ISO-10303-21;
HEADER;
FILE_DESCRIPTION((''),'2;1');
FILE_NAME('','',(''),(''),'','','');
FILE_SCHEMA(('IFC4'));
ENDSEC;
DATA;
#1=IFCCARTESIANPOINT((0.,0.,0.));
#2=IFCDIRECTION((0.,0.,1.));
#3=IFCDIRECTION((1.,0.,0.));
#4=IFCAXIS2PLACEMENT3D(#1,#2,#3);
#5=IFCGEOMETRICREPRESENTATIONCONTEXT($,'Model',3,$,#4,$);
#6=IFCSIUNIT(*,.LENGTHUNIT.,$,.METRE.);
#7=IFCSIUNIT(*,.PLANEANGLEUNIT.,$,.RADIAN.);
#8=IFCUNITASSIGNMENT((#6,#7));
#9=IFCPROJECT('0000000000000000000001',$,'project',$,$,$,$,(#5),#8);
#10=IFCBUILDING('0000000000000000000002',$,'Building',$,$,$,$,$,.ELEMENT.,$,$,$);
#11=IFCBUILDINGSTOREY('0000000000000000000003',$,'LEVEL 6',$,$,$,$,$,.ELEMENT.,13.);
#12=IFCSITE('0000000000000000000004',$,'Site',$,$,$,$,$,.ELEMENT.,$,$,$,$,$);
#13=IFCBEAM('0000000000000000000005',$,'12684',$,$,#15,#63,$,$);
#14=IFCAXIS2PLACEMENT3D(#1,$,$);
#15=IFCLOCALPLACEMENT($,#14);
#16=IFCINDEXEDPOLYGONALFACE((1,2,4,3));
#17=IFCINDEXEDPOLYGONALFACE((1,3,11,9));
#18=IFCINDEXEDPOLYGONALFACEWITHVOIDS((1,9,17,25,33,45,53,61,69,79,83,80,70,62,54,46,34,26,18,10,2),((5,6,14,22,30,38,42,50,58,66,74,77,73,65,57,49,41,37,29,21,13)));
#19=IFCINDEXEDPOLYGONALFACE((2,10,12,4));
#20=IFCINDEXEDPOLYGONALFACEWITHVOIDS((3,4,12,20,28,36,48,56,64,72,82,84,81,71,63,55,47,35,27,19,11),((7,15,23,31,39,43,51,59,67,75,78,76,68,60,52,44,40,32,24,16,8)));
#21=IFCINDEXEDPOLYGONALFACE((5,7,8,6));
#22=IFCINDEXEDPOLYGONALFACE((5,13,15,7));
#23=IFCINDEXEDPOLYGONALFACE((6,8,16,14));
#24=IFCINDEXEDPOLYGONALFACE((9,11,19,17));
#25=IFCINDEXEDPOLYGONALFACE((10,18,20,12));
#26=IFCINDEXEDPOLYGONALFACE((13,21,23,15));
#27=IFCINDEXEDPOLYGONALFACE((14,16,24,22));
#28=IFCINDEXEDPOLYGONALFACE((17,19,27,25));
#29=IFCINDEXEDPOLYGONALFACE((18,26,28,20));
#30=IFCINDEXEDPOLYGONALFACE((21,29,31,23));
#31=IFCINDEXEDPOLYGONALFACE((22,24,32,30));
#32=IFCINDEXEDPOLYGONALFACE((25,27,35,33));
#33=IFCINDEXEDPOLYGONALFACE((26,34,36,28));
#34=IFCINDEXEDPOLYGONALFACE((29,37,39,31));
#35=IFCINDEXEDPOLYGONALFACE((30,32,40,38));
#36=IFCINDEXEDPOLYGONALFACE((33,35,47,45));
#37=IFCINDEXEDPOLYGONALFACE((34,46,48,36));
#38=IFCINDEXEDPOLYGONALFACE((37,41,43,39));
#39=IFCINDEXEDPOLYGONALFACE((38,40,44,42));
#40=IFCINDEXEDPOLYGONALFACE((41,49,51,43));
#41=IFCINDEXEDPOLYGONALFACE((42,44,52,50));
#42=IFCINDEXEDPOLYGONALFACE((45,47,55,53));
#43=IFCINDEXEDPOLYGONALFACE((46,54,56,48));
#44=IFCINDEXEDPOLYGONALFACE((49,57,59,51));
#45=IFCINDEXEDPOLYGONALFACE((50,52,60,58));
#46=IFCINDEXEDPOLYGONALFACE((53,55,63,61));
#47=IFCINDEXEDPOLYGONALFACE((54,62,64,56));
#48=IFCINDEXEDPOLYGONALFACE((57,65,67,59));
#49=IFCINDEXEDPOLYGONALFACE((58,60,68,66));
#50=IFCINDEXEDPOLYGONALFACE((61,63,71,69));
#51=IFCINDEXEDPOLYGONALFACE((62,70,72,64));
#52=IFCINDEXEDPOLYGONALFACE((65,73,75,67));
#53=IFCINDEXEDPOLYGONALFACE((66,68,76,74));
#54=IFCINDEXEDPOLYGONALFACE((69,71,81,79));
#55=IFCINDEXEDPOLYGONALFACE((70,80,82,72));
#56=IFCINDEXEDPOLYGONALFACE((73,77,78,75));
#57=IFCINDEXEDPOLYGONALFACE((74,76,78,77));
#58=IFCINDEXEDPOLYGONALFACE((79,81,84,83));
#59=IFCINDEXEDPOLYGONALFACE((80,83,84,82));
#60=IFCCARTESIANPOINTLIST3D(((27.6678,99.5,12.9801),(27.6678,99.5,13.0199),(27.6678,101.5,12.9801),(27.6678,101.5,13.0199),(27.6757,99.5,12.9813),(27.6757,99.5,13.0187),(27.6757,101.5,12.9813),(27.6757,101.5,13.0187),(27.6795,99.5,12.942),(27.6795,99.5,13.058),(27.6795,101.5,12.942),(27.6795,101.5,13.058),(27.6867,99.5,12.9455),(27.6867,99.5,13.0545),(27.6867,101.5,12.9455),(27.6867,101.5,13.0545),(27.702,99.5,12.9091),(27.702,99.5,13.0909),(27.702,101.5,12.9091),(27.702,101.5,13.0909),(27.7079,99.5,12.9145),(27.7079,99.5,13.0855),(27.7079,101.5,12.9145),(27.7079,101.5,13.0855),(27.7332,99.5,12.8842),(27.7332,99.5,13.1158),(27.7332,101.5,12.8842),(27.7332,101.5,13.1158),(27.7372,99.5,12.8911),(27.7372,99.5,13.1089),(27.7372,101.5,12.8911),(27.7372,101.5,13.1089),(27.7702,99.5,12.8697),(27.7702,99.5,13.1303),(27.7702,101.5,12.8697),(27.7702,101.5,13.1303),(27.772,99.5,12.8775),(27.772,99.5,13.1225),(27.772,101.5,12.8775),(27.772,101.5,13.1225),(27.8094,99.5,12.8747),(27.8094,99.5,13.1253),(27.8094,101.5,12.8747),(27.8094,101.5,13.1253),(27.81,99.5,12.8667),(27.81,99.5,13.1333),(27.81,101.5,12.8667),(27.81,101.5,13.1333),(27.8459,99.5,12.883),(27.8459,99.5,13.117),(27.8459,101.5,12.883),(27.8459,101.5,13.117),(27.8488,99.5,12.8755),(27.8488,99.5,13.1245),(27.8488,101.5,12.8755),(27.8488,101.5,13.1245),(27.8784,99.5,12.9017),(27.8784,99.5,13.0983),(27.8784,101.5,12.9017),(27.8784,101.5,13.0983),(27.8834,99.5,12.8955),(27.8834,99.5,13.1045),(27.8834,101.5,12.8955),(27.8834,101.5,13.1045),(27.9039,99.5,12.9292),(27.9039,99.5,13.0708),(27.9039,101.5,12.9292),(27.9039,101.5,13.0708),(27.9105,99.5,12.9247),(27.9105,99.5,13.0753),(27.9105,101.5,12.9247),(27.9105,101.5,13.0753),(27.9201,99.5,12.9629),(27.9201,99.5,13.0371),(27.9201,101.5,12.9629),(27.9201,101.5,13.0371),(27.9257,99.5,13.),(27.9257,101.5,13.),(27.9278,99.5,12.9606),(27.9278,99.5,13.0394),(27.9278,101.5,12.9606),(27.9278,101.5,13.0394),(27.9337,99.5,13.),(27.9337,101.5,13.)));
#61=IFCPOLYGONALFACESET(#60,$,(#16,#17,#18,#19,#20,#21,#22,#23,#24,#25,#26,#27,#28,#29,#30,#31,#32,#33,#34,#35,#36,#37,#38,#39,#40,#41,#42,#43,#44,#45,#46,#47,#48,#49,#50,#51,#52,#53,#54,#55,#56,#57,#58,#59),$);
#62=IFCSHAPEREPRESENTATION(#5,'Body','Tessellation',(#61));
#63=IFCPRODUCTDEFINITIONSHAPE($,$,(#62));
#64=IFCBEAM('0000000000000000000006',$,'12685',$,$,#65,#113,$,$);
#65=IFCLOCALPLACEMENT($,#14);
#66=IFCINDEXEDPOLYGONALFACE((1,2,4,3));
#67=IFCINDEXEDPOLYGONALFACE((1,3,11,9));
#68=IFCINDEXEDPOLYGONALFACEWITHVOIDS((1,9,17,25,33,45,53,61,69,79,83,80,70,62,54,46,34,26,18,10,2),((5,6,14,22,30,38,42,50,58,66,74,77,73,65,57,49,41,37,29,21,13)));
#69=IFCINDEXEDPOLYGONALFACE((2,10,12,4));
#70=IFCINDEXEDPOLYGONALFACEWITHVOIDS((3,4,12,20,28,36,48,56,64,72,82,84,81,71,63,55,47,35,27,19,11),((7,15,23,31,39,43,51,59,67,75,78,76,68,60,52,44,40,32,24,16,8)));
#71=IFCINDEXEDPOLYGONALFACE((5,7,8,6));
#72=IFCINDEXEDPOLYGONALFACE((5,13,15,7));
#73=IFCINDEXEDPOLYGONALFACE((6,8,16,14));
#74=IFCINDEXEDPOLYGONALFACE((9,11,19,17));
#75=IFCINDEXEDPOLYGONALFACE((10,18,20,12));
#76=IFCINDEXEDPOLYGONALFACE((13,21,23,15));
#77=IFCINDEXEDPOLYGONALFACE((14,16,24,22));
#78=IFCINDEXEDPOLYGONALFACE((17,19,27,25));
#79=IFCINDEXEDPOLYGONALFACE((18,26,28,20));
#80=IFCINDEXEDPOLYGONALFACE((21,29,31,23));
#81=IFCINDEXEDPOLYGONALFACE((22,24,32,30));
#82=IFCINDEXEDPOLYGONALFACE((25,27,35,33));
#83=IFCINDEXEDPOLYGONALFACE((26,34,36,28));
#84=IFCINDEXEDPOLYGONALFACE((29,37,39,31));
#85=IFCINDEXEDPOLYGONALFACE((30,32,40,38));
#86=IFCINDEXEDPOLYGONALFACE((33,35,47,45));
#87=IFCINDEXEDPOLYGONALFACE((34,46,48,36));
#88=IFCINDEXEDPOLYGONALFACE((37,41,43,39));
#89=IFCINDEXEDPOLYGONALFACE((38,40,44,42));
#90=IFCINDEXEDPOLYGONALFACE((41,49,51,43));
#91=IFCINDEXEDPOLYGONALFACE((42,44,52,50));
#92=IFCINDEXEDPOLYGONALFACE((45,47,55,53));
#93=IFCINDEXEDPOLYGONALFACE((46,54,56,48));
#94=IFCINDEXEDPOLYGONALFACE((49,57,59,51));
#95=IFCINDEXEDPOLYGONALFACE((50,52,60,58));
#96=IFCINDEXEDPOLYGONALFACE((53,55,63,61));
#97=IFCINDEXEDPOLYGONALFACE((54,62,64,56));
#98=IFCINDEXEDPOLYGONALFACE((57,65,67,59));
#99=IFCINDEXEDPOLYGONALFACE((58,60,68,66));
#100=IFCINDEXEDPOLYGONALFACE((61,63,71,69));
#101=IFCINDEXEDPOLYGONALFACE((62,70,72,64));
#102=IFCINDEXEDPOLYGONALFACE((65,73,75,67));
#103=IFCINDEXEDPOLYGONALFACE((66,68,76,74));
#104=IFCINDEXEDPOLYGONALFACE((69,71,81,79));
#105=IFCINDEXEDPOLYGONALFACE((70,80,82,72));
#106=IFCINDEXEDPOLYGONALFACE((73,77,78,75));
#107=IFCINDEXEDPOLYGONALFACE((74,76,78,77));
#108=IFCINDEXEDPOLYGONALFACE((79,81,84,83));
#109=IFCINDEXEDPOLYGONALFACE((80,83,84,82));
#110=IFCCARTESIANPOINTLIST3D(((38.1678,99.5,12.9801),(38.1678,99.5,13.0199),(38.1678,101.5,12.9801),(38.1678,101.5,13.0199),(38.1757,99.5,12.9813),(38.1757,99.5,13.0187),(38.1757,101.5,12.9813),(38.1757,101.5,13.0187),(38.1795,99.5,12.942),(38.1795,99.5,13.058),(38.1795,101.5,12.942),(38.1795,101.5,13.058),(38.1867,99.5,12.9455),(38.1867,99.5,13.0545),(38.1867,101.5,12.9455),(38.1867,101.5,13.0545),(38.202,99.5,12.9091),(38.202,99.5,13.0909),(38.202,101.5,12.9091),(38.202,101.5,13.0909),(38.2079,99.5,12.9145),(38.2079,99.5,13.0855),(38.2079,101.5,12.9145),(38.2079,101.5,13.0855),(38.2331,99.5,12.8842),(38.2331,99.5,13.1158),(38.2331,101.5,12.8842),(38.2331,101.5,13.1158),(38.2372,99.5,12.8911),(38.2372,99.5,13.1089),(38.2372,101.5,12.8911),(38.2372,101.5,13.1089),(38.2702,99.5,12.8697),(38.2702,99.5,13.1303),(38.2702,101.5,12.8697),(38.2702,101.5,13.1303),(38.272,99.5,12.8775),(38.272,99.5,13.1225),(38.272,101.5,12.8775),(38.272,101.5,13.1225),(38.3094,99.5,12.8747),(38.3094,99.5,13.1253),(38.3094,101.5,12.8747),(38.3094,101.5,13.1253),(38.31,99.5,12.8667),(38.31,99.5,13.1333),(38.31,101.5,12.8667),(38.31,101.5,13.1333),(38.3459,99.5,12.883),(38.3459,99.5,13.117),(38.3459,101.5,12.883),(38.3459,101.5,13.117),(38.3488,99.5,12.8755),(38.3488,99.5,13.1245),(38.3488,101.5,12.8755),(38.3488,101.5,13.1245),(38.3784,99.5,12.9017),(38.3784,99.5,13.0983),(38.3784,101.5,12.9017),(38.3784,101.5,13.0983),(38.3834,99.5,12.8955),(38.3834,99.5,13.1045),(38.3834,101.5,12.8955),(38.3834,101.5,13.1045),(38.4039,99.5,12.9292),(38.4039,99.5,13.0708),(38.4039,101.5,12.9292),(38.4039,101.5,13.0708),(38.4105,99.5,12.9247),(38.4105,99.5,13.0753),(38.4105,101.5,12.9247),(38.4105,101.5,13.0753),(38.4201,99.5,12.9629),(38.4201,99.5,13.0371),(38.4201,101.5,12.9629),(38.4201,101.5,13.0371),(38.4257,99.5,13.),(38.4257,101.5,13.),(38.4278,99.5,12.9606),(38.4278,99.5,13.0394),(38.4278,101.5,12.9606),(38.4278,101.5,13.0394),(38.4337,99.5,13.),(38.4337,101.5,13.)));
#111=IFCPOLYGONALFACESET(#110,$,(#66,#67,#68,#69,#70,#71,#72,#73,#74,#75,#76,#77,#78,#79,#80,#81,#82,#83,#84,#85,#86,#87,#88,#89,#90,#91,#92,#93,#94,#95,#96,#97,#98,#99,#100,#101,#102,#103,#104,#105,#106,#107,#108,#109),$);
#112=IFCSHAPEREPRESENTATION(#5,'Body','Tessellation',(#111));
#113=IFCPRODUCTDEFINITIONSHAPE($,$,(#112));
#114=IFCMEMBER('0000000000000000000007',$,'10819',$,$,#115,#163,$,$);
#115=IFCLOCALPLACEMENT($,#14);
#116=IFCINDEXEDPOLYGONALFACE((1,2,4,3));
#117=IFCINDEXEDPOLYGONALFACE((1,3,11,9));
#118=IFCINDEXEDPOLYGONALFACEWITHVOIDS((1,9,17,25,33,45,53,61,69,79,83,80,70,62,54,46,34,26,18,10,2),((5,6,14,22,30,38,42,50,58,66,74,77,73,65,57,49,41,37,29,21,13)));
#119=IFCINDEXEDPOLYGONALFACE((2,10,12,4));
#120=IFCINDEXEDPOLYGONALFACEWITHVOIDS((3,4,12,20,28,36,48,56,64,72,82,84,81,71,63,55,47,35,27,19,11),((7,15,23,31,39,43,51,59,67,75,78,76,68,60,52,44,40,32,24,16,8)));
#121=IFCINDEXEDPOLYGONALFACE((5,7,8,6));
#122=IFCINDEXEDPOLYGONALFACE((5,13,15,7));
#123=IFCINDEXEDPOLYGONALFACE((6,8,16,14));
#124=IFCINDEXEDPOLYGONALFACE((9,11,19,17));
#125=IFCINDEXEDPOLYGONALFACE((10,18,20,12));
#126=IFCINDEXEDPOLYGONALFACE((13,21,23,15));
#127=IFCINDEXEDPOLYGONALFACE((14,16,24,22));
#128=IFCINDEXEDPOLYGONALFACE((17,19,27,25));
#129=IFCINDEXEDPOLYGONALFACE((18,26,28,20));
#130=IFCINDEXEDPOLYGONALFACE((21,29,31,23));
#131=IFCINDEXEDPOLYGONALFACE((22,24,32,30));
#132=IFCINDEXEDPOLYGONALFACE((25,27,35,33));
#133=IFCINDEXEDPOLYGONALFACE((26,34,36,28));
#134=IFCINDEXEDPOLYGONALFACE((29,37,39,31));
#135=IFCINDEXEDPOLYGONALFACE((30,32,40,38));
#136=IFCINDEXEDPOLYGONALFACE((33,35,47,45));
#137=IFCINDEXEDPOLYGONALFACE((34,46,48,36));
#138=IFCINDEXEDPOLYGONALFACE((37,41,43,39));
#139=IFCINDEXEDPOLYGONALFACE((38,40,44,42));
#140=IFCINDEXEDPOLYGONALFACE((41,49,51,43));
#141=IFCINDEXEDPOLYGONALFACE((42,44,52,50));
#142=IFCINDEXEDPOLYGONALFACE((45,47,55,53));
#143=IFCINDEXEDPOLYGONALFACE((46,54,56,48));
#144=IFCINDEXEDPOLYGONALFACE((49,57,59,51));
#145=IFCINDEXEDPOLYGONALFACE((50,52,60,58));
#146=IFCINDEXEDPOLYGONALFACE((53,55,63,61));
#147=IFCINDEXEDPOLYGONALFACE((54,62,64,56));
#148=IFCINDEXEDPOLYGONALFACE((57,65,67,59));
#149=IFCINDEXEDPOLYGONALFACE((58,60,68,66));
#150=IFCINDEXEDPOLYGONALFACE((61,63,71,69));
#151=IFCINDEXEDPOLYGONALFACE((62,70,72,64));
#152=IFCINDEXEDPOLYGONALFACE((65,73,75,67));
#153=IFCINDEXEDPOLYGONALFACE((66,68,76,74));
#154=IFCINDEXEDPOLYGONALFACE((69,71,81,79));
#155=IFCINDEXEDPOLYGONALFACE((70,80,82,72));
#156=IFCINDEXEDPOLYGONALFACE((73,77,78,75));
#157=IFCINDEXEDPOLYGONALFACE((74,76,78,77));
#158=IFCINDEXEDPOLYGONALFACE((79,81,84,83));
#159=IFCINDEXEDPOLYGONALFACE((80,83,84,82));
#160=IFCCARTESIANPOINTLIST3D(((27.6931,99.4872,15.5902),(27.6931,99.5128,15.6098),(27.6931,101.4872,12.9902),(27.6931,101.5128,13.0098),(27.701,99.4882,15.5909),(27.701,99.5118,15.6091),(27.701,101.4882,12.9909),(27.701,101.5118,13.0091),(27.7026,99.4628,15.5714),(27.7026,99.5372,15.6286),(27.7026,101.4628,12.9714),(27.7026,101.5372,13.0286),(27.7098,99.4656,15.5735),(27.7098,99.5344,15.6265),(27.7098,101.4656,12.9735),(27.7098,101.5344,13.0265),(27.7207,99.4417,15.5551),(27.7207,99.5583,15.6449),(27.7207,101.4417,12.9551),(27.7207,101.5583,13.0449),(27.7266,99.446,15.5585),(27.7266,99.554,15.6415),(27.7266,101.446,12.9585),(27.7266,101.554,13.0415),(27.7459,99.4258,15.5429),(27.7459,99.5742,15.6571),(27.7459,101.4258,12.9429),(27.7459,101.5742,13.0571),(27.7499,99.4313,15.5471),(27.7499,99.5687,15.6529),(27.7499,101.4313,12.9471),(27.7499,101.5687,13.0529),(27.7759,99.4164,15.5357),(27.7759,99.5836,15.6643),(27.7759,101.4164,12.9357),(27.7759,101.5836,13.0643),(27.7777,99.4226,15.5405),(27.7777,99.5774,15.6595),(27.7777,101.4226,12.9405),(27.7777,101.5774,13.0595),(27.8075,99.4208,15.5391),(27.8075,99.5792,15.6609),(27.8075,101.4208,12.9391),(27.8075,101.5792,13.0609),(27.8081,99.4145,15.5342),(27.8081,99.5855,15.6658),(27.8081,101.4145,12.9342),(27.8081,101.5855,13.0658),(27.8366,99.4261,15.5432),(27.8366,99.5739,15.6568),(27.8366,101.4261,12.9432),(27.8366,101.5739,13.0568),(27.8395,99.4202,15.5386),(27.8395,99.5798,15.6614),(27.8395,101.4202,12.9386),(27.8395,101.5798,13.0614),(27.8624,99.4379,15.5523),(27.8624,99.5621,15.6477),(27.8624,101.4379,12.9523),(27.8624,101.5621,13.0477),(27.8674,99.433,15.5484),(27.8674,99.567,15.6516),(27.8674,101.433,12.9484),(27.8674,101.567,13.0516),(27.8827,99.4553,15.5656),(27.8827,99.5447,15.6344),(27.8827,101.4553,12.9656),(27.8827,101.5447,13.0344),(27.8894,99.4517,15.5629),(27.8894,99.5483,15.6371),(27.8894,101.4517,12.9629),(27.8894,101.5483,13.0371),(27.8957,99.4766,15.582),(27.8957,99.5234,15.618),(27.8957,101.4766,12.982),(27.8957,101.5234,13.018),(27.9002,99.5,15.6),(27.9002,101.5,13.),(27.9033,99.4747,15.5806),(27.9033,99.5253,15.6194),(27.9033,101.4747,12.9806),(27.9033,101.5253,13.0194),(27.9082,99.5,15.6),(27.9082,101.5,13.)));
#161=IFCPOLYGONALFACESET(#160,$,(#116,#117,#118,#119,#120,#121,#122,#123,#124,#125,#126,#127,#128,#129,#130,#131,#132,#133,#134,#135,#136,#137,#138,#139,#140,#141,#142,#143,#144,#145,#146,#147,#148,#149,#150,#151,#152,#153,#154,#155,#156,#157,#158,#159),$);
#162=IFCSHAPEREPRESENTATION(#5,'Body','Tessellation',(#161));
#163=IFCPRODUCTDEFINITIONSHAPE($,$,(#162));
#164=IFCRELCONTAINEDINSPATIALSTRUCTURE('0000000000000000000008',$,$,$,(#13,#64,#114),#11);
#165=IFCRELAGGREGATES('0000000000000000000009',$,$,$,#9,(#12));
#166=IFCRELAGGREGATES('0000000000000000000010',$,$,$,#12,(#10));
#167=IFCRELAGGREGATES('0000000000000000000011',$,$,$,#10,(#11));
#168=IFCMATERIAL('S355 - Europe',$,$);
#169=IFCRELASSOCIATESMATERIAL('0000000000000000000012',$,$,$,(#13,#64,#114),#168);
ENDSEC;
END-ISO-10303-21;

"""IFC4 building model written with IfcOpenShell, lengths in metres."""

from ifc_helpers import new_model, si_unit, frame, origin_with_axes, origin_2d_with_axis, place, context, project, spatial, hollow_circle, extrude, material, material_profile, profile_set, profile_usage, element, save


model = new_model("IFC4")

# Units and contexts
model_context = context("Model", 3, world=origin_with_axes())
ifc_project = project(units=[si_unit("LENGTHUNIT", "METRE"), si_unit("PLANEANGLEUNIT", "RADIAN")], contexts=[model_context])

# Site, building, storey
site = spatial("IfcSite", under=ifc_project, Name="Site", CompositionType="ELEMENT")
building = spatial("IfcBuilding", under=site, Name="Building", CompositionType="ELEMENT")
storey = spatial("IfcBuildingStorey", under=building, Name="LEVEL 6", CompositionType="ELEMENT", Elevation=13.0)

# Shared definitions
ifc_material = material(Name="S355 - Europe")

# Beams
ifc_material_profile_1 = material_profile(ifc_material, hollow_circle(Radius=0.1337, WallThickness=0.008, at=origin_2d_with_axis()))
ifc_profile_set_1 = profile_set([ifc_material_profile_1])
ifc_profile_usage_1 = profile_usage(ifc_profile_set_1, cardinal=10)
beam_1_placement = place(None, frame((27.8, 101.5, 13.0), z_axis=(0.0, -1.0, 0.0), x_axis=(1.0, 0.0, 0.0)))
element("IfcBeam", 1, at=beam_1_placement, inside=storey, material=ifc_profile_usage_1, Name="12684", context=model_context, shape_type="SweptSolid", body=[
    extrude(hollow_circle(Radius=0.1337, WallThickness=0.008, at=origin_2d_with_axis()), origin_with_axes(), (0.0, 0.0, 1.0), 2.0),
])
ifc_material_profile_2 = material_profile(ifc_material, hollow_circle(Radius=0.1337, WallThickness=0.008, at=origin_2d_with_axis()))
ifc_profile_set_2 = profile_set([ifc_material_profile_2])
ifc_profile_usage_2 = profile_usage(ifc_profile_set_2, cardinal=10)
beam_2_placement = place(None, frame((38.3, 101.5, 13.0), z_axis=(0.0, -1.0, 0.0), x_axis=(1.0, 0.0, 0.0)))
element("IfcBeam", 2, at=beam_2_placement, inside=storey, material=ifc_profile_usage_2, Name="12685", context=model_context, shape_type="SweptSolid", body=[
    extrude(hollow_circle(Radius=0.1337, WallThickness=0.008, at=origin_2d_with_axis()), origin_with_axes(), (0.0, 0.0, 1.0), 2.0),
])

# Member
ifc_material_profile_3 = material_profile(ifc_material, hollow_circle(Radius=0.1081, WallThickness=0.008, at=origin_2d_with_axis()))
ifc_profile_set_3 = profile_set([ifc_material_profile_3])
ifc_profile_usage_3 = profile_usage(ifc_profile_set_3, cardinal=10)
member_1_placement = place(None, frame((27.8, 101.5, 13.0), z_axis=(0.0, -0.609711, 0.792624), x_axis=(1.0, 0.0, 0.0)))
element("IfcMember", 3, at=member_1_placement, inside=storey, material=ifc_profile_usage_3, Name="10819", context=model_context, shape_type="SweptSolid", body=[
    extrude(hollow_circle(Radius=0.1081, WallThickness=0.008, at=origin_2d_with_axis()), origin_with_axes(), (0.0, 0.0, 1.0), 3.2802),
])

save(model, "model.ifc")
